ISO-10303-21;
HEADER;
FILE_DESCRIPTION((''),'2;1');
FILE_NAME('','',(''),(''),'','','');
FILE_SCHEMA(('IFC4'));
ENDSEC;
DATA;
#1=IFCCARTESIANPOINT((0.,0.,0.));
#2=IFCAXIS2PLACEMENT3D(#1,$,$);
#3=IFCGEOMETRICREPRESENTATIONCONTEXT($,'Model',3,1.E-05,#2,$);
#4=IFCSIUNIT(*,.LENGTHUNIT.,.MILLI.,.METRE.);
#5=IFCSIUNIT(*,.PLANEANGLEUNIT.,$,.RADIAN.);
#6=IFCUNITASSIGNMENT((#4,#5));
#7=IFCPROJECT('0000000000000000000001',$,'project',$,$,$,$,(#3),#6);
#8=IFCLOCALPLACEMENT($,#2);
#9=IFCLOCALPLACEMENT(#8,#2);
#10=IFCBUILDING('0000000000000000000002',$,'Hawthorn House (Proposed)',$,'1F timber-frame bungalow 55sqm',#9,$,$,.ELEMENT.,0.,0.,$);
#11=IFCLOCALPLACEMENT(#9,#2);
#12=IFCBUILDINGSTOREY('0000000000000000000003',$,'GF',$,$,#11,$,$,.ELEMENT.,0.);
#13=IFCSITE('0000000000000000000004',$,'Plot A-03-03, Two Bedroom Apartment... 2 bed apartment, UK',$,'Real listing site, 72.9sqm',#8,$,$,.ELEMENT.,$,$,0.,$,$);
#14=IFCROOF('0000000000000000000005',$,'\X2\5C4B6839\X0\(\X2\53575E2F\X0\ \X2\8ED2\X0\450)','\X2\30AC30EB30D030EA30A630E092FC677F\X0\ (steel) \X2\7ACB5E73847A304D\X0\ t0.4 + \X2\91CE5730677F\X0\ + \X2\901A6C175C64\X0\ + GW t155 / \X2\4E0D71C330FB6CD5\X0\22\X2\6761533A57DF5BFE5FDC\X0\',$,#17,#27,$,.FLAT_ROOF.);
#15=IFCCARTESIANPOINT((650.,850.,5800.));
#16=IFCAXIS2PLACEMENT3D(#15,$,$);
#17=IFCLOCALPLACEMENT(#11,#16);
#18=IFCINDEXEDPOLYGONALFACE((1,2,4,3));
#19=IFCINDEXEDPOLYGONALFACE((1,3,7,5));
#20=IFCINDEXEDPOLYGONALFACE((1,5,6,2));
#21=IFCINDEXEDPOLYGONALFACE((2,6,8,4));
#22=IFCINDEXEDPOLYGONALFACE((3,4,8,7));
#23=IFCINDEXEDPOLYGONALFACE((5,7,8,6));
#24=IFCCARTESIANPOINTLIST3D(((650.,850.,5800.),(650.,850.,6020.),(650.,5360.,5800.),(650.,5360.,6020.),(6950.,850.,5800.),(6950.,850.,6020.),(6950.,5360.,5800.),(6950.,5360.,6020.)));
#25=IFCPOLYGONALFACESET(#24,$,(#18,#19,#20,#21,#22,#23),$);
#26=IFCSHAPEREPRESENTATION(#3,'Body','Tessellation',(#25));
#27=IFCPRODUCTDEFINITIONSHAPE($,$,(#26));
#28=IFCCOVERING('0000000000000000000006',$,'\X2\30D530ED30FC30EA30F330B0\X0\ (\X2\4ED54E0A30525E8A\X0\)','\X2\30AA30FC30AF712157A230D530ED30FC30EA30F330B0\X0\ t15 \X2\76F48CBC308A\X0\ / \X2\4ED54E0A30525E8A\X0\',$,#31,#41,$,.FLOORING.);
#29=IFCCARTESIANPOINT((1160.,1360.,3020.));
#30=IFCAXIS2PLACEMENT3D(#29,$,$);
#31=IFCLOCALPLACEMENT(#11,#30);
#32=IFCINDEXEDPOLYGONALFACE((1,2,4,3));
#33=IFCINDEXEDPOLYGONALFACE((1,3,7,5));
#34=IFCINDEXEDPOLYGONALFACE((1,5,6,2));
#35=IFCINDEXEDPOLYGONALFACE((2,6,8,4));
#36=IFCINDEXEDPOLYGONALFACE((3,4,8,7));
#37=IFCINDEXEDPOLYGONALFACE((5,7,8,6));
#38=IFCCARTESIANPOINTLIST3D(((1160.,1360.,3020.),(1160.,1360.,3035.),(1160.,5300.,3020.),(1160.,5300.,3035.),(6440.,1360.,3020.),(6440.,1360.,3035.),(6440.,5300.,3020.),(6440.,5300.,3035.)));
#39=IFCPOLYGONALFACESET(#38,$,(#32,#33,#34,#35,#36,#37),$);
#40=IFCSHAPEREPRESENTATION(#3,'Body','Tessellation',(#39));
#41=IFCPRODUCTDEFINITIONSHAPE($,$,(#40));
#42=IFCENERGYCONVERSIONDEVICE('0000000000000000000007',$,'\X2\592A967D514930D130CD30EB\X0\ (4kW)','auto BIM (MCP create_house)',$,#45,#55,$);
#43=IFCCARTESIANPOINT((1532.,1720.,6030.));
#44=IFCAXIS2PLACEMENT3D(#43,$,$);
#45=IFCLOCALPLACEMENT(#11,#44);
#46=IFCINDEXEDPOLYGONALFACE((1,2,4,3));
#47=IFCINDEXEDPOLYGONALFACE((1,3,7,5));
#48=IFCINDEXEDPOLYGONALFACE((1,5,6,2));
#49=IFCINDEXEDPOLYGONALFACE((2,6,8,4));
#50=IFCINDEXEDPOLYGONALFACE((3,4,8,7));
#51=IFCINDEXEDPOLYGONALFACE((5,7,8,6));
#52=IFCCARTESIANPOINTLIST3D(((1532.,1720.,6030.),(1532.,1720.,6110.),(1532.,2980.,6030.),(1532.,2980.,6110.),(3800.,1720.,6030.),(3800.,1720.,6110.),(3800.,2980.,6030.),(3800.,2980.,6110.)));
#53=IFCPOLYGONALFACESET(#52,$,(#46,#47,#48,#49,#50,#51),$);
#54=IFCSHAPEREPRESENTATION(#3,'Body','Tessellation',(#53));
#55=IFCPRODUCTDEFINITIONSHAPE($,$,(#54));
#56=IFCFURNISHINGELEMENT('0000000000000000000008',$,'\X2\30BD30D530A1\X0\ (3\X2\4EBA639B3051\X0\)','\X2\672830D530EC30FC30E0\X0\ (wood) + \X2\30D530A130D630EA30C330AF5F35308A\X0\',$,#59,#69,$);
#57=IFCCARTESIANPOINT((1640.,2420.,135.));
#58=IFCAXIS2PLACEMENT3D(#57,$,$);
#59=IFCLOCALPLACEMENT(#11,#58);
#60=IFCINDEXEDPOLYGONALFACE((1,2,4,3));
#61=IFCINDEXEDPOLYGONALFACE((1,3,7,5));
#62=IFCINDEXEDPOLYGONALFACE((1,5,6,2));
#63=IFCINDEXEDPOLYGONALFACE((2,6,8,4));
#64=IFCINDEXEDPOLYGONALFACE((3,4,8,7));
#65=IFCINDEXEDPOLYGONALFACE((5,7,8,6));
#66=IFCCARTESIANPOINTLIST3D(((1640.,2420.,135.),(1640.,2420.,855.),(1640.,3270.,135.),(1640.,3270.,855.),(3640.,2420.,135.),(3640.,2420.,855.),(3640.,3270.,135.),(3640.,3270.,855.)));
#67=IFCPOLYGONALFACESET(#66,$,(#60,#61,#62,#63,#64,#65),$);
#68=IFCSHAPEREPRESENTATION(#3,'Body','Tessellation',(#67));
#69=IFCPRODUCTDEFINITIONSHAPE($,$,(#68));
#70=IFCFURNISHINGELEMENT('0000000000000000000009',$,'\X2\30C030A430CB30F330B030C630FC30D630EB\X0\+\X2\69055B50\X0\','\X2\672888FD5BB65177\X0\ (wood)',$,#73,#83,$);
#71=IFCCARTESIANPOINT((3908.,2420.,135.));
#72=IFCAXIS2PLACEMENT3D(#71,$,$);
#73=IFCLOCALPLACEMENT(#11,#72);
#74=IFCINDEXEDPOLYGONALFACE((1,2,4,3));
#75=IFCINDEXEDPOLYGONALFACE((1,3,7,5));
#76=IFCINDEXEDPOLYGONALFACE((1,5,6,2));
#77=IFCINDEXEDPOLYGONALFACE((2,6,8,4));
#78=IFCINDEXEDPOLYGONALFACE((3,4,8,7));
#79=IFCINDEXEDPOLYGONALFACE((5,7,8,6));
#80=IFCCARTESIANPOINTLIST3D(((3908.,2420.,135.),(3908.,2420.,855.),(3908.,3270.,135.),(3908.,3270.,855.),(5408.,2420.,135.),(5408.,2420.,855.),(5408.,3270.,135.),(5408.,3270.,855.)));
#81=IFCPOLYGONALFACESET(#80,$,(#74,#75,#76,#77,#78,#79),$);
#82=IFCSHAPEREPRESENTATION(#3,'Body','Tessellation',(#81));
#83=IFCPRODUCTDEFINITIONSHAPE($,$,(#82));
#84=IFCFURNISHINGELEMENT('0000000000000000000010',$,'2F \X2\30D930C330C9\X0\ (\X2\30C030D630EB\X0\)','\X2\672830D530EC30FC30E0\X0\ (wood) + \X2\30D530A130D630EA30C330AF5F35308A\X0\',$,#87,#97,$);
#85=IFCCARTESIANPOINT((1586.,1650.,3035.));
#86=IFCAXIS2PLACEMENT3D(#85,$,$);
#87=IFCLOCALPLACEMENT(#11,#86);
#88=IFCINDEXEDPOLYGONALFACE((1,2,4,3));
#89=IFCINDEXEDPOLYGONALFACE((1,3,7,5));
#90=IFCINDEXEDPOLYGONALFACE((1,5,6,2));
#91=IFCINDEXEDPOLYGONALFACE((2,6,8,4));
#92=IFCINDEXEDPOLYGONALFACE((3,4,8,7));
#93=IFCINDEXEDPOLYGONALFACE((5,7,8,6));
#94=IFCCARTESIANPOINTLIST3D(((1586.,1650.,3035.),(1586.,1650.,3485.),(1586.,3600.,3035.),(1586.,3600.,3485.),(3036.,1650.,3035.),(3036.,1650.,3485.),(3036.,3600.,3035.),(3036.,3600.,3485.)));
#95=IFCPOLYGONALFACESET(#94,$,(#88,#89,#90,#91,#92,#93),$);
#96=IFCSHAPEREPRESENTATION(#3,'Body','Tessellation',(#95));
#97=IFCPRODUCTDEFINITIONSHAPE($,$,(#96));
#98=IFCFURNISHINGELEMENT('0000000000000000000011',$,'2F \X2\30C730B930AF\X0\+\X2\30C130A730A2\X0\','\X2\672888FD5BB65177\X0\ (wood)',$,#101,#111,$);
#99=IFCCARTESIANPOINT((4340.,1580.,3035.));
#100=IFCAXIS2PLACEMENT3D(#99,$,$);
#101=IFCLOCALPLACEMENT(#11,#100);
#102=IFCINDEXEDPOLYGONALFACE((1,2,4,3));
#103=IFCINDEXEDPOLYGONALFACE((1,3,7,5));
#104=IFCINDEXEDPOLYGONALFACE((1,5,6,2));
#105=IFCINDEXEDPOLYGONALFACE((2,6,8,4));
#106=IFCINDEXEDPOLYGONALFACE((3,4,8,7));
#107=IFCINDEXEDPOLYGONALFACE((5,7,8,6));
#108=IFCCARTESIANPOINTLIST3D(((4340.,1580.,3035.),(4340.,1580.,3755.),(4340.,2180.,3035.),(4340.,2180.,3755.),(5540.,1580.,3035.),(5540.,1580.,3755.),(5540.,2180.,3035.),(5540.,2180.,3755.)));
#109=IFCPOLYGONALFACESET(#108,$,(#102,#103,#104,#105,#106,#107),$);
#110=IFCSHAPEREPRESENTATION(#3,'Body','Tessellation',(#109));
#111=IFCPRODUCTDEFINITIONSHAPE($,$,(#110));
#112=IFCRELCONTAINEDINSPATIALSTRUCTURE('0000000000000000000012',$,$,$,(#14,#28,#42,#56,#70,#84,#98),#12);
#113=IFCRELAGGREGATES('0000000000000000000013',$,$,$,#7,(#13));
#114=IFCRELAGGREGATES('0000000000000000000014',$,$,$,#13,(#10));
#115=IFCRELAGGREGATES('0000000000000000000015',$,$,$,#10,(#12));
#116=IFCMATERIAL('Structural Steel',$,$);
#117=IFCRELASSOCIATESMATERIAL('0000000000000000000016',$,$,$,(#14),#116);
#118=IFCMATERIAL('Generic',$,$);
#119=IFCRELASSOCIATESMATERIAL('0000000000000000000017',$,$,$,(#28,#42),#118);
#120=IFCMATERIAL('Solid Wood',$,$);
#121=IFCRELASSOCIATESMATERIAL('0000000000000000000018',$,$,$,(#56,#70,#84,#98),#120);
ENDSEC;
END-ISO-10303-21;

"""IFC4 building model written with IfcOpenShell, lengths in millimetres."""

from ifc_helpers import new_model, si_unit, frame, frame_2d, origin, place, context, project, spatial, rectangle, extrude, material, element, save


model = new_model("IFC4")

# Units and contexts
model_context = context("Model", 3, precision=1e-05, world=origin())
ifc_project = project(units=[si_unit("LENGTHUNIT", "METRE", prefix="MILLI"), si_unit("PLANEANGLEUNIT", "RADIAN")], contexts=[model_context])

# Site, building, storey
site_placement = place(None, origin())
site = spatial("IfcSite", under=ifc_project, at=site_placement, Name="Plot A-03-03, Two Bedroom Apartment... 2 bed apartment, UK", ObjectType="Real listing site, 72.9sqm", CompositionType="ELEMENT", RefElevation=0.0)
building_placement = place(site_placement, origin())
building = spatial("IfcBuilding", under=site, at=building_placement, Name="Hawthorn House (Proposed)", ObjectType="1F timber-frame bungalow 55sqm", CompositionType="ELEMENT", ElevationOfRefHeight=0.0, ElevationOfTerrain=0.0)
storey_placement = place(building_placement, origin())
storey = spatial("IfcBuildingStorey", under=building, at=storey_placement, Name="GF", CompositionType="ELEMENT", Elevation=0.0)

# Shared definitions
ifc_material_1 = material(Name="Solid Wood")

# Shared definitions
ifc_material_2 = material(Name="Generic")

# Roof
ifc_material_3 = material(Name="Structural Steel")
for number, where, name in (
    (1, (650.0, 850.0, 5800.0), "屋根(南帯 軒450)"),
):
    element("IfcRoof", number, at=place(storey_placement, frame(where)), inside=storey, material=ifc_material_3, Name=name, Description="ガルバリウム鋼板 (steel) 立平葺き t0.4 + 野地板 + 通気層 + GW t155 / 不燃・法22条区域対応", PredefinedType="FLAT_ROOF", context=model_context, shape_type="SweptSolid", body=[
        extrude(rectangle(XDim=6300.0, YDim=4510.0, at=frame_2d((3150.0, 2255.0))), frame((650.0, 850.0, 5800.0)), (0.0, 0.0, 1.0), 220.0),
    ])

# Covering
covering_placement = place(storey_placement, frame((1160.0, 1360.0, 3020.0)))
element("IfcCovering", 2, at=covering_placement, inside=storey, material=ifc_material_2, Name="フローリング (仕上げ床)", Description="オーク無垢フローリング t15 直貼り / 仕上げ床", PredefinedType="FLOORING", context=model_context, shape_type="SweptSolid", body=[
    extrude(rectangle(XDim=5280.0, YDim=3940.0, at=frame_2d((2640.0, 1970.0))), frame((1160.0, 1360.0, 3020.0)), (0.0, 0.0, 1.0), 15.0),
])

# Energy conversion device
energy_conversion_device_placement = place(storey_placement, frame((1532.0, 1720.0, 6030.0)))
element("IfcEnergyConversionDevice", 3, at=energy_conversion_device_placement, inside=storey, material=ifc_material_2, Name="太陽光パネル (4kW)", Description="auto BIM (MCP create_house)", context=model_context, shape_type="SweptSolid", body=[
    extrude(rectangle(XDim=2268.0, YDim=1260.0, at=frame_2d((1134.0, 630.0))), frame((1532.0, 1720.0, 6030.0)), (0.0, 0.0, 1.0), 80.0),
])

# Furnishing elements
furnishing_1_placement = place(storey_placement, frame((1640.0, 2420.0, 135.0)))
element("IfcFurnishingElement", 4, at=furnishing_1_placement, inside=storey, material=ifc_material_1, Name="ソファ (3人掛け)", Description="木フレーム (wood) + ファブリック張り", context=model_context, shape_type="SweptSolid", body=[
    extrude(rectangle(XDim=2000.0, YDim=850.0, at=frame_2d((1000.0, 425.0))), frame((1640.0, 2420.0, 135.0)), (0.0, 0.0, 1.0), 720.0),
])
furnishing_2_placement = place(storey_placement, frame((3908.0, 2420.0, 135.0)))
element("IfcFurnishingElement", 5, at=furnishing_2_placement, inside=storey, material=ifc_material_1, Name="ダイニングテーブル+椅子", Description="木製家具 (wood)", context=model_context, shape_type="SweptSolid", body=[
    extrude(rectangle(XDim=1500.0, YDim=850.0, at=frame_2d((750.0, 425.0))), frame((3908.0, 2420.0, 135.0)), (0.0, 0.0, 1.0), 720.0),
])
furnishing_3_placement = place(storey_placement, frame((1586.0, 1650.0, 3035.0)))
element("IfcFurnishingElement", 6, at=furnishing_3_placement, inside=storey, material=ifc_material_1, Name="2F ベッド (ダブル)", Description="木フレーム (wood) + ファブリック張り", context=model_context, shape_type="SweptSolid", body=[
    extrude(rectangle(XDim=1450.0, YDim=1950.0, at=frame_2d((725.0, 975.0))), frame((1586.0, 1650.0, 3035.0)), (0.0, 0.0, 1.0), 450.0),
])
furnishing_4_placement = place(storey_placement, frame((4340.0, 1580.0, 3035.0)))
element("IfcFurnishingElement", 7, at=furnishing_4_placement, inside=storey, material=ifc_material_1, Name="2F デスク+チェア", Description="木製家具 (wood)", context=model_context, shape_type="SweptSolid", body=[
    extrude(rectangle(XDim=1200.0, YDim=600.0, at=frame_2d((600.0, 300.0))), frame((4340.0, 1580.0, 3035.0)), (0.0, 0.0, 1.0), 720.0),
])

save(model, "model.ifc")
